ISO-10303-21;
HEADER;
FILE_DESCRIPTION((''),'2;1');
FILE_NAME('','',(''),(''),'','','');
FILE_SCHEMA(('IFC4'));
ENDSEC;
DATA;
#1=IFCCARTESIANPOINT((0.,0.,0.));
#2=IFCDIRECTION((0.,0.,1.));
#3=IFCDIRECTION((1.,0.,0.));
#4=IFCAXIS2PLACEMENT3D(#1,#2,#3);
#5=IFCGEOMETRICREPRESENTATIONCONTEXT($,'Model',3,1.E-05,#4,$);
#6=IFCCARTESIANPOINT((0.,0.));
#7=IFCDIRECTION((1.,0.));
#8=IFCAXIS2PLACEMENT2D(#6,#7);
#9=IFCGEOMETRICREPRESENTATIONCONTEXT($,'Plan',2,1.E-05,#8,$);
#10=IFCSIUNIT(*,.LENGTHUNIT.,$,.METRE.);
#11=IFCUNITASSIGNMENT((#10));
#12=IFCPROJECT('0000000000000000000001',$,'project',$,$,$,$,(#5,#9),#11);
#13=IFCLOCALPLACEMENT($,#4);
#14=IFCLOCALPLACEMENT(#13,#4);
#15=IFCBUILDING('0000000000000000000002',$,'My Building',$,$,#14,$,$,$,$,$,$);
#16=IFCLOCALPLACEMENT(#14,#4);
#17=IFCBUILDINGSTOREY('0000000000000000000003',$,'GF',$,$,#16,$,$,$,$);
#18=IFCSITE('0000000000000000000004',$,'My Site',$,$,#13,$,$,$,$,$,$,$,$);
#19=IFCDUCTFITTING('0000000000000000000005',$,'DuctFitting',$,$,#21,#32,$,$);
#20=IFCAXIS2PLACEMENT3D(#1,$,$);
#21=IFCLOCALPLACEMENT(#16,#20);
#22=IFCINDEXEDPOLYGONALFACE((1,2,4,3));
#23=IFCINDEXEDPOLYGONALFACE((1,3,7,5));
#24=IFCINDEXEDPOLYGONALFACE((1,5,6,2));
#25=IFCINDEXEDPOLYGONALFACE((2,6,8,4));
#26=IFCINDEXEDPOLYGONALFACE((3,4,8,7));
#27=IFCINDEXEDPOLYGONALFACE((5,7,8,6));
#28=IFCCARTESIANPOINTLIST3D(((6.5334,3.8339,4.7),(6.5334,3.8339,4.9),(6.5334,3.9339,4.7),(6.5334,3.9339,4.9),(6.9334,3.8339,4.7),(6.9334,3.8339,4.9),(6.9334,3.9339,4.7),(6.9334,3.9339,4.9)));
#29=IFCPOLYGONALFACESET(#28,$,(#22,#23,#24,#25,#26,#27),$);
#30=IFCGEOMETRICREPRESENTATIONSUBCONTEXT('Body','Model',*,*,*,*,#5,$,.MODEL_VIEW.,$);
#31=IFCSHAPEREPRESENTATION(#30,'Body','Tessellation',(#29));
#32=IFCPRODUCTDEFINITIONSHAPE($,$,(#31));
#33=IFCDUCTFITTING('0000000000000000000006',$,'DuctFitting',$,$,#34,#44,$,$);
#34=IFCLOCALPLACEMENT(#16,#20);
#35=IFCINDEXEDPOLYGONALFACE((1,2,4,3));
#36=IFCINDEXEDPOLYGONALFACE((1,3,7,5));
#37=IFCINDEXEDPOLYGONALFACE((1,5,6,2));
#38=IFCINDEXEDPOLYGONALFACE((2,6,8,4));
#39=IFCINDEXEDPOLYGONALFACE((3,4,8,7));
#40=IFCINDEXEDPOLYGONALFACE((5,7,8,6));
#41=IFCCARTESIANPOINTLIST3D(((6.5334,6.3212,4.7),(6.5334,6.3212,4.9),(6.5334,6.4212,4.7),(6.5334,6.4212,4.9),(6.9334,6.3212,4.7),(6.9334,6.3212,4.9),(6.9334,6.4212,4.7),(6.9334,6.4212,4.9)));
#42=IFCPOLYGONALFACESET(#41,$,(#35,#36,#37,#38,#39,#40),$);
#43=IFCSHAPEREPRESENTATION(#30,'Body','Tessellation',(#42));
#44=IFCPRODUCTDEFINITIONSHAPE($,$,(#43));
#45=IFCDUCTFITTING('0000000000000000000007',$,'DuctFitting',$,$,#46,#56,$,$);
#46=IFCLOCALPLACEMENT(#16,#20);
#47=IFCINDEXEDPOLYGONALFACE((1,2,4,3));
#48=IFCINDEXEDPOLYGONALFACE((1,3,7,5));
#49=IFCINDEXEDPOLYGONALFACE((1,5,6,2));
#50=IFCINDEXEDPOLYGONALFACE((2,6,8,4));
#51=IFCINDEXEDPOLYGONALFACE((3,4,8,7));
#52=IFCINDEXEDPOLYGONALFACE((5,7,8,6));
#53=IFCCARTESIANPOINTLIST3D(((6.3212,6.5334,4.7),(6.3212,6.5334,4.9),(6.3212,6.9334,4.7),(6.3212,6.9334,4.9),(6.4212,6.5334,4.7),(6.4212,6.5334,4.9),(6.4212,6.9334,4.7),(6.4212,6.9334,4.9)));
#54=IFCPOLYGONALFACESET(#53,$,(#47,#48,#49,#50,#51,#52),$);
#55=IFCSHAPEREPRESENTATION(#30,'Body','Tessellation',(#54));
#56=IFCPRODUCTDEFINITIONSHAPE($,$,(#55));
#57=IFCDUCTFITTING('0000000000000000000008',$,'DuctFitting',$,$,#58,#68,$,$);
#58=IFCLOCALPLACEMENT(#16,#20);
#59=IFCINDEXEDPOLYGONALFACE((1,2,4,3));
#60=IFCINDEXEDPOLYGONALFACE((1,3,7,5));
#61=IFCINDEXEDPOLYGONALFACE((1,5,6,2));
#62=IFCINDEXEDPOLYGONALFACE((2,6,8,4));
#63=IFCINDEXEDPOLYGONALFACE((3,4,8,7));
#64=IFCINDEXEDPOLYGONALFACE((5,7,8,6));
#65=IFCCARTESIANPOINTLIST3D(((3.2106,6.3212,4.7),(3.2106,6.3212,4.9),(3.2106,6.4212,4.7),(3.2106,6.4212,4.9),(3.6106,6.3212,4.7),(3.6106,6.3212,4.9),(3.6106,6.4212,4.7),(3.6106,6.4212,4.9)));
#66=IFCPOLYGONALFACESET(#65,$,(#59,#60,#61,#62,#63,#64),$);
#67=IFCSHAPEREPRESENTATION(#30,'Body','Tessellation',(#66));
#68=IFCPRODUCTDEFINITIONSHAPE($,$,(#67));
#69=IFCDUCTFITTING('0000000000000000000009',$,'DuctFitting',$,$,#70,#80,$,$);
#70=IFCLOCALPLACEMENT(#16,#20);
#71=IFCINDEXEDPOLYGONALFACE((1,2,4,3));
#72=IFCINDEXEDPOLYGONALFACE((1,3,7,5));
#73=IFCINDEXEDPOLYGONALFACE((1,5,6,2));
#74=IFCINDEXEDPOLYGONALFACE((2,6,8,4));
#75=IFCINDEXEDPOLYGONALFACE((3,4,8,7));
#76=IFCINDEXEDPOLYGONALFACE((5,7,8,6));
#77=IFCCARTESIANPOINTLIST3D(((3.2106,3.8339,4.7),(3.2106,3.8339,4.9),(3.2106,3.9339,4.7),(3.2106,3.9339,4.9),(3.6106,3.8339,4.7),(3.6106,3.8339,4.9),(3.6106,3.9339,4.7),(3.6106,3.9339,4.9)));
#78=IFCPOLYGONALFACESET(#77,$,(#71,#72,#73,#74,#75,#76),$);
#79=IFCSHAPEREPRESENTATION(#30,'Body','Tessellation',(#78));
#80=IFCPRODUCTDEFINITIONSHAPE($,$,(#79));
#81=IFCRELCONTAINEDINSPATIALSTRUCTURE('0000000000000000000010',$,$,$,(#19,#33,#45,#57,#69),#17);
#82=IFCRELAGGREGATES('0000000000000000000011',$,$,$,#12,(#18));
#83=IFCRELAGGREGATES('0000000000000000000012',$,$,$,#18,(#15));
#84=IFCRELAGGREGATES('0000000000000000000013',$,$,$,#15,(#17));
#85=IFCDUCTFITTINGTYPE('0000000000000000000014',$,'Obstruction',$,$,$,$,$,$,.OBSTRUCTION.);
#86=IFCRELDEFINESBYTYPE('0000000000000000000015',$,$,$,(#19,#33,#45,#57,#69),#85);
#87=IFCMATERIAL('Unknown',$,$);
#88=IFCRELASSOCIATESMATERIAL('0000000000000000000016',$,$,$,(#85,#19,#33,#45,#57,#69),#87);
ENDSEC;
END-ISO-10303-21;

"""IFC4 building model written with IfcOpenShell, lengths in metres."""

from ifc_helpers import new_model, si_unit, frame, origin_with_axes, origin_2d_with_axis, place, context, subcontext, project, spatial, rectangle, extrude, material, material_profile, profile_set, profile_usage, type_object, element, save


model = new_model("IFC4")

# Units and contexts
model_context = context("Model", 3, precision=1e-05, world=origin_with_axes())
plan_context = context("Plan", 2, precision=1e-05, world=origin_2d_with_axis())
body_context_1 = subcontext(model_context, "Body", "Model", "MODEL_VIEW")
ifc_project = project(units=[si_unit("LENGTHUNIT", "METRE")], contexts=[model_context, plan_context])

# Site, building, storey
site_placement = place(None, origin_with_axes())
site = spatial("IfcSite", under=ifc_project, at=site_placement, Name="My Site")
building_placement = place(site_placement, origin_with_axes())
building = spatial("IfcBuilding", under=site, at=building_placement, Name="My Building")
storey_placement = place(building_placement, origin_with_axes())
storey = spatial("IfcBuildingStorey", under=building, at=storey_placement, Name="GF")

# Shared definitions
ifc_material = material(Name="Unknown")

# Duct fittings
ifc_material_profile_1 = material_profile(ifc_material, rectangle(XDim=0.4, YDim=0.2))
ifc_profile_set_1 = profile_set([ifc_material_profile_1])
duct_fitting_type = type_object("IfcDuctFittingType", Name="Obstruction", PredefinedType="OBSTRUCTION", material=ifc_profile_set_1)
ifc_profile_usage_1 = profile_usage(ifc_profile_set_1, cardinal=5)
duct_fitting_1_placement = place(storey_placement, frame((6.7334, 3.9339, 4.8), z_axis=(0.0, -1.0, 0.000001), x_axis=(1.0, 0.0, 0.0)))
element("IfcDuctFitting", 1, at=duct_fitting_1_placement, inside=storey, type_object=duct_fitting_type, material=ifc_profile_usage_1, Name="DuctFitting", context=body_context_1, shape_type="SweptSolid", body=[
    extrude(rectangle(XDim=0.4, YDim=0.2), origin_with_axes(), (0.0, 0.0, 1.0), 0.1),
])
ifc_profile_usage_2 = profile_usage(ifc_profile_set_1, cardinal=5)
duct_fitting_2_placement = place(storey_placement, frame((6.7334, 6.4212, 4.8), z_axis=(0.0, -1.0, 0.000001), x_axis=(1.0, 0.0, 0.0)))
element("IfcDuctFitting", 2, at=duct_fitting_2_placement, inside=storey, type_object=duct_fitting_type, material=ifc_profile_usage_2, Name="DuctFitting", context=body_context_1, shape_type="SweptSolid", body=[
    extrude(rectangle(XDim=0.4, YDim=0.2), origin_with_axes(), (0.0, 0.0, 1.0), 0.1),
])
ifc_profile_usage_3 = profile_usage(ifc_profile_set_1, cardinal=5)
duct_fitting_3_placement = place(storey_placement, frame((6.3212, 6.7334, 4.8), z_axis=(1.0, 0.0, 0.0), x_axis=(0.0, 1.0, 0.0)))
element("IfcDuctFitting", 3, at=duct_fitting_3_placement, inside=storey, type_object=duct_fitting_type, material=ifc_profile_usage_3, Name="DuctFitting", context=body_context_1, shape_type="SweptSolid", body=[
    extrude(rectangle(XDim=0.4, YDim=0.2), origin_with_axes(), (0.0, 0.0, 1.0), 0.1),
])
ifc_profile_usage_4 = profile_usage(ifc_profile_set_1, cardinal=5)
duct_fitting_4_placement = place(storey_placement, frame((3.4106, 6.4212, 4.8), z_axis=(0.0, -1.0, 0.0), x_axis=(1.0, 0.0, 0.0)))
element("IfcDuctFitting", 4, at=duct_fitting_4_placement, inside=storey, type_object=duct_fitting_type, material=ifc_profile_usage_4, Name="DuctFitting", context=body_context_1, shape_type="SweptSolid", body=[
    extrude(rectangle(XDim=0.4, YDim=0.2), origin_with_axes(), (0.0, 0.0, 1.0), 0.1),
])
ifc_profile_usage_5 = profile_usage(ifc_profile_set_1, cardinal=5)
duct_fitting_5_placement = place(storey_placement, frame((3.4106, 3.9339, 4.8), z_axis=(0.0, -1.0, 0.0), x_axis=(1.0, 0.0, 0.0)))
element("IfcDuctFitting", 5, at=duct_fitting_5_placement, inside=storey, type_object=duct_fitting_type, material=ifc_profile_usage_5, Name="DuctFitting", context=body_context_1, shape_type="SweptSolid", body=[
    extrude(rectangle(XDim=0.4, YDim=0.2), origin_with_axes(), (0.0, 0.0, 1.0), 0.1),
])

save(model, "model.ifc")
